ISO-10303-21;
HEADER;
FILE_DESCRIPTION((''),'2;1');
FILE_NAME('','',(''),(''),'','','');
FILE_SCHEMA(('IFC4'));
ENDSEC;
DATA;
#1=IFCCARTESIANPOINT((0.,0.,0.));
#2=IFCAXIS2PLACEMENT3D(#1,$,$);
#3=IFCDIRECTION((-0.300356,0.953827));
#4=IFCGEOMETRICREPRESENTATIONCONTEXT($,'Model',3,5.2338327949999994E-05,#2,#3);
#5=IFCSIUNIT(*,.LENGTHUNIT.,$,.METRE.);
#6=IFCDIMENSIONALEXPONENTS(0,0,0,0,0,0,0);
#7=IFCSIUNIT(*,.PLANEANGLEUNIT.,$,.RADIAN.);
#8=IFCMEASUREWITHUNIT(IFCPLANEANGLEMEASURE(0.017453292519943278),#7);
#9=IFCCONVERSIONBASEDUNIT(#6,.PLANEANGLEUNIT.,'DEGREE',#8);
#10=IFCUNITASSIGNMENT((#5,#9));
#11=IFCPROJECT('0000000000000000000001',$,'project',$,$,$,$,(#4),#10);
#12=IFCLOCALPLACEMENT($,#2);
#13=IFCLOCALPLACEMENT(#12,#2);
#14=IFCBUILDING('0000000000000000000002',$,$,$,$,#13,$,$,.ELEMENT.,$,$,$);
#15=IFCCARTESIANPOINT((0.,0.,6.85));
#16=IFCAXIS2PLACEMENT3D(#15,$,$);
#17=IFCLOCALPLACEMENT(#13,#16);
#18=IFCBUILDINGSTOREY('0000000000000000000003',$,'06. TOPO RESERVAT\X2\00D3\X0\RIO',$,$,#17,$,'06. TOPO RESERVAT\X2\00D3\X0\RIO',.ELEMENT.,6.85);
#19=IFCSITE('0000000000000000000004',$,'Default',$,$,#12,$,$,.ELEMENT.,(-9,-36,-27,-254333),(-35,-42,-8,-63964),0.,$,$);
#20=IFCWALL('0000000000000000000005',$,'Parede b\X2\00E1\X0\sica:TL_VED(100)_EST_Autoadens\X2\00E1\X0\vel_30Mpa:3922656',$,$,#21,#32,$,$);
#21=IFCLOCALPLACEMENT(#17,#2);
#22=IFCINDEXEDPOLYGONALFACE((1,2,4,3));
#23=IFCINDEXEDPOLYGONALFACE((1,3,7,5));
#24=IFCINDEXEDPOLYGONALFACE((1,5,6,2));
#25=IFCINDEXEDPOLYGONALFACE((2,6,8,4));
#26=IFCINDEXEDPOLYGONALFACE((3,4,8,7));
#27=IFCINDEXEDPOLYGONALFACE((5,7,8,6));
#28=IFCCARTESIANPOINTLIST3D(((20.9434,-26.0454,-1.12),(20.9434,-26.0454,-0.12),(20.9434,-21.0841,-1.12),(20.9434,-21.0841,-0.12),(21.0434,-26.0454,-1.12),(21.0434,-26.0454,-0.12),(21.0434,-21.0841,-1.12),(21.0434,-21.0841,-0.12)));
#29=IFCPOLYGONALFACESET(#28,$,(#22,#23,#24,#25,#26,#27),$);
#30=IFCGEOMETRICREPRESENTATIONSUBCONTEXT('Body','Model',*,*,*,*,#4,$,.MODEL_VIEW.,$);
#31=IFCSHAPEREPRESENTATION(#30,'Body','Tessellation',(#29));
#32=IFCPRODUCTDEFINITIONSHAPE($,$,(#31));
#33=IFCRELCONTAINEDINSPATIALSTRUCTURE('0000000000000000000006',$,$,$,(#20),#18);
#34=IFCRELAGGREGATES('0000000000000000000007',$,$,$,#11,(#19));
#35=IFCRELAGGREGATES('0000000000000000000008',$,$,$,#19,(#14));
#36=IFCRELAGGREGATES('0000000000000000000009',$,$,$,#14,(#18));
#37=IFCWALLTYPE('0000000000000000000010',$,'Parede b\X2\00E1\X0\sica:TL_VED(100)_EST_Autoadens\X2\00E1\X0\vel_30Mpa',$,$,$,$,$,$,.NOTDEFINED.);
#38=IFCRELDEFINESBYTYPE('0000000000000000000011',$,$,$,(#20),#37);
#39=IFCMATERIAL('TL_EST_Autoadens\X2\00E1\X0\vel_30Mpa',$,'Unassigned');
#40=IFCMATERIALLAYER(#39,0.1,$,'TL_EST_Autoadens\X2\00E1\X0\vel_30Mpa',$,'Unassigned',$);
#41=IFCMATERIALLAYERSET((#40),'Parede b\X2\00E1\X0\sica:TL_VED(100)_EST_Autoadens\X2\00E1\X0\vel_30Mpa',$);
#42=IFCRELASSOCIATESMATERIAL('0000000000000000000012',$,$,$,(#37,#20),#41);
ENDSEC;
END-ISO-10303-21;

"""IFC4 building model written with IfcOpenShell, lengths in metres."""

from ifc_helpers import new_model, entity, si_unit, converted_unit, direction, frame, frame_2d, origin, place, context, subcontext, project, spatial, rectangle, extrude, material, layer, layer_set, layer_usage, type_object, element, save


model = new_model("IFC4")

# Units and contexts
model_context = context("Model", 3, precision=5.2338327949999994e-05, world=origin(), true_north=direction((-0.300356, 0.953827)))
body_context = subcontext(model_context, "Body", "Model", "MODEL_VIEW")
ifc_project = project(units=[si_unit("LENGTHUNIT", "METRE"), converted_unit("PLANEANGLEUNIT", "DEGREE", entity("IfcPlaneAngleMeasure", 0.017453292519943278), si_unit("PLANEANGLEUNIT", "RADIAN"), dimensions=[0, 0, 0, 0, 0, 0, 0])], contexts=[model_context])

# Site, building, storey
site_placement = place(None, origin())
site = spatial("IfcSite", under=ifc_project, at=site_placement, Name="Default", CompositionType="ELEMENT", RefLatitude=(-9, -36, -27, -254333), RefLongitude=(-35, -42, -8, -63964), RefElevation=0.0)
building_placement = place(site_placement, origin())
building = spatial("IfcBuilding", under=site, at=building_placement, CompositionType="ELEMENT")
storey_placement = place(building_placement, frame((0.0, 0.0, 6.85)))
storey = spatial("IfcBuildingStorey", under=building, at=storey_placement, Name="06. TOPO RESERVATÓRIO", LongName="06. TOPO RESERVATÓRIO", CompositionType="ELEMENT", Elevation=6.85)

# Wall
ifc_material_1 = material(Name="TL_EST_Autoadensável_30Mpa", Category="Unassigned")
ifc_layer = layer(ifc_material_1, 0.1, Name="TL_EST_Autoadensável_30Mpa", Category="Unassigned")
ifc_layer_set = layer_set([ifc_layer], Name="Parede básica:TL_VED(100)_EST_Autoadensável_30Mpa")
ifc_layer_usage = layer_usage(ifc_layer_set, "AXIS2", "POSITIVE", -0.05)
wall_type = type_object("IfcWallType", Name="Parede básica:TL_VED(100)_EST_Autoadensável_30Mpa", PredefinedType="NOTDEFINED", material=ifc_layer_set)
wall_placement = place(storey_placement, frame((20.9934, -21.0841, -1.12), z_axis=(0.0, 0.0, 1.0), x_axis=(0.0, -1.0, 0.0)))
element("IfcWall", 1, at=wall_placement, inside=storey, type_object=wall_type, material=ifc_layer_usage, Name="Parede básica:TL_VED(100)_EST_Autoadensável_30Mpa:3922656", context=body_context, shape_type="SweptSolid", body=[
    extrude(rectangle(XDim=4.9613, YDim=0.1, at=frame_2d((2.4806, 0.0), x_axis=(-1.0, 0.0))), origin(), (0.0, 0.0, 1.0), 1.0),
])

save(model, "model.ifc")
